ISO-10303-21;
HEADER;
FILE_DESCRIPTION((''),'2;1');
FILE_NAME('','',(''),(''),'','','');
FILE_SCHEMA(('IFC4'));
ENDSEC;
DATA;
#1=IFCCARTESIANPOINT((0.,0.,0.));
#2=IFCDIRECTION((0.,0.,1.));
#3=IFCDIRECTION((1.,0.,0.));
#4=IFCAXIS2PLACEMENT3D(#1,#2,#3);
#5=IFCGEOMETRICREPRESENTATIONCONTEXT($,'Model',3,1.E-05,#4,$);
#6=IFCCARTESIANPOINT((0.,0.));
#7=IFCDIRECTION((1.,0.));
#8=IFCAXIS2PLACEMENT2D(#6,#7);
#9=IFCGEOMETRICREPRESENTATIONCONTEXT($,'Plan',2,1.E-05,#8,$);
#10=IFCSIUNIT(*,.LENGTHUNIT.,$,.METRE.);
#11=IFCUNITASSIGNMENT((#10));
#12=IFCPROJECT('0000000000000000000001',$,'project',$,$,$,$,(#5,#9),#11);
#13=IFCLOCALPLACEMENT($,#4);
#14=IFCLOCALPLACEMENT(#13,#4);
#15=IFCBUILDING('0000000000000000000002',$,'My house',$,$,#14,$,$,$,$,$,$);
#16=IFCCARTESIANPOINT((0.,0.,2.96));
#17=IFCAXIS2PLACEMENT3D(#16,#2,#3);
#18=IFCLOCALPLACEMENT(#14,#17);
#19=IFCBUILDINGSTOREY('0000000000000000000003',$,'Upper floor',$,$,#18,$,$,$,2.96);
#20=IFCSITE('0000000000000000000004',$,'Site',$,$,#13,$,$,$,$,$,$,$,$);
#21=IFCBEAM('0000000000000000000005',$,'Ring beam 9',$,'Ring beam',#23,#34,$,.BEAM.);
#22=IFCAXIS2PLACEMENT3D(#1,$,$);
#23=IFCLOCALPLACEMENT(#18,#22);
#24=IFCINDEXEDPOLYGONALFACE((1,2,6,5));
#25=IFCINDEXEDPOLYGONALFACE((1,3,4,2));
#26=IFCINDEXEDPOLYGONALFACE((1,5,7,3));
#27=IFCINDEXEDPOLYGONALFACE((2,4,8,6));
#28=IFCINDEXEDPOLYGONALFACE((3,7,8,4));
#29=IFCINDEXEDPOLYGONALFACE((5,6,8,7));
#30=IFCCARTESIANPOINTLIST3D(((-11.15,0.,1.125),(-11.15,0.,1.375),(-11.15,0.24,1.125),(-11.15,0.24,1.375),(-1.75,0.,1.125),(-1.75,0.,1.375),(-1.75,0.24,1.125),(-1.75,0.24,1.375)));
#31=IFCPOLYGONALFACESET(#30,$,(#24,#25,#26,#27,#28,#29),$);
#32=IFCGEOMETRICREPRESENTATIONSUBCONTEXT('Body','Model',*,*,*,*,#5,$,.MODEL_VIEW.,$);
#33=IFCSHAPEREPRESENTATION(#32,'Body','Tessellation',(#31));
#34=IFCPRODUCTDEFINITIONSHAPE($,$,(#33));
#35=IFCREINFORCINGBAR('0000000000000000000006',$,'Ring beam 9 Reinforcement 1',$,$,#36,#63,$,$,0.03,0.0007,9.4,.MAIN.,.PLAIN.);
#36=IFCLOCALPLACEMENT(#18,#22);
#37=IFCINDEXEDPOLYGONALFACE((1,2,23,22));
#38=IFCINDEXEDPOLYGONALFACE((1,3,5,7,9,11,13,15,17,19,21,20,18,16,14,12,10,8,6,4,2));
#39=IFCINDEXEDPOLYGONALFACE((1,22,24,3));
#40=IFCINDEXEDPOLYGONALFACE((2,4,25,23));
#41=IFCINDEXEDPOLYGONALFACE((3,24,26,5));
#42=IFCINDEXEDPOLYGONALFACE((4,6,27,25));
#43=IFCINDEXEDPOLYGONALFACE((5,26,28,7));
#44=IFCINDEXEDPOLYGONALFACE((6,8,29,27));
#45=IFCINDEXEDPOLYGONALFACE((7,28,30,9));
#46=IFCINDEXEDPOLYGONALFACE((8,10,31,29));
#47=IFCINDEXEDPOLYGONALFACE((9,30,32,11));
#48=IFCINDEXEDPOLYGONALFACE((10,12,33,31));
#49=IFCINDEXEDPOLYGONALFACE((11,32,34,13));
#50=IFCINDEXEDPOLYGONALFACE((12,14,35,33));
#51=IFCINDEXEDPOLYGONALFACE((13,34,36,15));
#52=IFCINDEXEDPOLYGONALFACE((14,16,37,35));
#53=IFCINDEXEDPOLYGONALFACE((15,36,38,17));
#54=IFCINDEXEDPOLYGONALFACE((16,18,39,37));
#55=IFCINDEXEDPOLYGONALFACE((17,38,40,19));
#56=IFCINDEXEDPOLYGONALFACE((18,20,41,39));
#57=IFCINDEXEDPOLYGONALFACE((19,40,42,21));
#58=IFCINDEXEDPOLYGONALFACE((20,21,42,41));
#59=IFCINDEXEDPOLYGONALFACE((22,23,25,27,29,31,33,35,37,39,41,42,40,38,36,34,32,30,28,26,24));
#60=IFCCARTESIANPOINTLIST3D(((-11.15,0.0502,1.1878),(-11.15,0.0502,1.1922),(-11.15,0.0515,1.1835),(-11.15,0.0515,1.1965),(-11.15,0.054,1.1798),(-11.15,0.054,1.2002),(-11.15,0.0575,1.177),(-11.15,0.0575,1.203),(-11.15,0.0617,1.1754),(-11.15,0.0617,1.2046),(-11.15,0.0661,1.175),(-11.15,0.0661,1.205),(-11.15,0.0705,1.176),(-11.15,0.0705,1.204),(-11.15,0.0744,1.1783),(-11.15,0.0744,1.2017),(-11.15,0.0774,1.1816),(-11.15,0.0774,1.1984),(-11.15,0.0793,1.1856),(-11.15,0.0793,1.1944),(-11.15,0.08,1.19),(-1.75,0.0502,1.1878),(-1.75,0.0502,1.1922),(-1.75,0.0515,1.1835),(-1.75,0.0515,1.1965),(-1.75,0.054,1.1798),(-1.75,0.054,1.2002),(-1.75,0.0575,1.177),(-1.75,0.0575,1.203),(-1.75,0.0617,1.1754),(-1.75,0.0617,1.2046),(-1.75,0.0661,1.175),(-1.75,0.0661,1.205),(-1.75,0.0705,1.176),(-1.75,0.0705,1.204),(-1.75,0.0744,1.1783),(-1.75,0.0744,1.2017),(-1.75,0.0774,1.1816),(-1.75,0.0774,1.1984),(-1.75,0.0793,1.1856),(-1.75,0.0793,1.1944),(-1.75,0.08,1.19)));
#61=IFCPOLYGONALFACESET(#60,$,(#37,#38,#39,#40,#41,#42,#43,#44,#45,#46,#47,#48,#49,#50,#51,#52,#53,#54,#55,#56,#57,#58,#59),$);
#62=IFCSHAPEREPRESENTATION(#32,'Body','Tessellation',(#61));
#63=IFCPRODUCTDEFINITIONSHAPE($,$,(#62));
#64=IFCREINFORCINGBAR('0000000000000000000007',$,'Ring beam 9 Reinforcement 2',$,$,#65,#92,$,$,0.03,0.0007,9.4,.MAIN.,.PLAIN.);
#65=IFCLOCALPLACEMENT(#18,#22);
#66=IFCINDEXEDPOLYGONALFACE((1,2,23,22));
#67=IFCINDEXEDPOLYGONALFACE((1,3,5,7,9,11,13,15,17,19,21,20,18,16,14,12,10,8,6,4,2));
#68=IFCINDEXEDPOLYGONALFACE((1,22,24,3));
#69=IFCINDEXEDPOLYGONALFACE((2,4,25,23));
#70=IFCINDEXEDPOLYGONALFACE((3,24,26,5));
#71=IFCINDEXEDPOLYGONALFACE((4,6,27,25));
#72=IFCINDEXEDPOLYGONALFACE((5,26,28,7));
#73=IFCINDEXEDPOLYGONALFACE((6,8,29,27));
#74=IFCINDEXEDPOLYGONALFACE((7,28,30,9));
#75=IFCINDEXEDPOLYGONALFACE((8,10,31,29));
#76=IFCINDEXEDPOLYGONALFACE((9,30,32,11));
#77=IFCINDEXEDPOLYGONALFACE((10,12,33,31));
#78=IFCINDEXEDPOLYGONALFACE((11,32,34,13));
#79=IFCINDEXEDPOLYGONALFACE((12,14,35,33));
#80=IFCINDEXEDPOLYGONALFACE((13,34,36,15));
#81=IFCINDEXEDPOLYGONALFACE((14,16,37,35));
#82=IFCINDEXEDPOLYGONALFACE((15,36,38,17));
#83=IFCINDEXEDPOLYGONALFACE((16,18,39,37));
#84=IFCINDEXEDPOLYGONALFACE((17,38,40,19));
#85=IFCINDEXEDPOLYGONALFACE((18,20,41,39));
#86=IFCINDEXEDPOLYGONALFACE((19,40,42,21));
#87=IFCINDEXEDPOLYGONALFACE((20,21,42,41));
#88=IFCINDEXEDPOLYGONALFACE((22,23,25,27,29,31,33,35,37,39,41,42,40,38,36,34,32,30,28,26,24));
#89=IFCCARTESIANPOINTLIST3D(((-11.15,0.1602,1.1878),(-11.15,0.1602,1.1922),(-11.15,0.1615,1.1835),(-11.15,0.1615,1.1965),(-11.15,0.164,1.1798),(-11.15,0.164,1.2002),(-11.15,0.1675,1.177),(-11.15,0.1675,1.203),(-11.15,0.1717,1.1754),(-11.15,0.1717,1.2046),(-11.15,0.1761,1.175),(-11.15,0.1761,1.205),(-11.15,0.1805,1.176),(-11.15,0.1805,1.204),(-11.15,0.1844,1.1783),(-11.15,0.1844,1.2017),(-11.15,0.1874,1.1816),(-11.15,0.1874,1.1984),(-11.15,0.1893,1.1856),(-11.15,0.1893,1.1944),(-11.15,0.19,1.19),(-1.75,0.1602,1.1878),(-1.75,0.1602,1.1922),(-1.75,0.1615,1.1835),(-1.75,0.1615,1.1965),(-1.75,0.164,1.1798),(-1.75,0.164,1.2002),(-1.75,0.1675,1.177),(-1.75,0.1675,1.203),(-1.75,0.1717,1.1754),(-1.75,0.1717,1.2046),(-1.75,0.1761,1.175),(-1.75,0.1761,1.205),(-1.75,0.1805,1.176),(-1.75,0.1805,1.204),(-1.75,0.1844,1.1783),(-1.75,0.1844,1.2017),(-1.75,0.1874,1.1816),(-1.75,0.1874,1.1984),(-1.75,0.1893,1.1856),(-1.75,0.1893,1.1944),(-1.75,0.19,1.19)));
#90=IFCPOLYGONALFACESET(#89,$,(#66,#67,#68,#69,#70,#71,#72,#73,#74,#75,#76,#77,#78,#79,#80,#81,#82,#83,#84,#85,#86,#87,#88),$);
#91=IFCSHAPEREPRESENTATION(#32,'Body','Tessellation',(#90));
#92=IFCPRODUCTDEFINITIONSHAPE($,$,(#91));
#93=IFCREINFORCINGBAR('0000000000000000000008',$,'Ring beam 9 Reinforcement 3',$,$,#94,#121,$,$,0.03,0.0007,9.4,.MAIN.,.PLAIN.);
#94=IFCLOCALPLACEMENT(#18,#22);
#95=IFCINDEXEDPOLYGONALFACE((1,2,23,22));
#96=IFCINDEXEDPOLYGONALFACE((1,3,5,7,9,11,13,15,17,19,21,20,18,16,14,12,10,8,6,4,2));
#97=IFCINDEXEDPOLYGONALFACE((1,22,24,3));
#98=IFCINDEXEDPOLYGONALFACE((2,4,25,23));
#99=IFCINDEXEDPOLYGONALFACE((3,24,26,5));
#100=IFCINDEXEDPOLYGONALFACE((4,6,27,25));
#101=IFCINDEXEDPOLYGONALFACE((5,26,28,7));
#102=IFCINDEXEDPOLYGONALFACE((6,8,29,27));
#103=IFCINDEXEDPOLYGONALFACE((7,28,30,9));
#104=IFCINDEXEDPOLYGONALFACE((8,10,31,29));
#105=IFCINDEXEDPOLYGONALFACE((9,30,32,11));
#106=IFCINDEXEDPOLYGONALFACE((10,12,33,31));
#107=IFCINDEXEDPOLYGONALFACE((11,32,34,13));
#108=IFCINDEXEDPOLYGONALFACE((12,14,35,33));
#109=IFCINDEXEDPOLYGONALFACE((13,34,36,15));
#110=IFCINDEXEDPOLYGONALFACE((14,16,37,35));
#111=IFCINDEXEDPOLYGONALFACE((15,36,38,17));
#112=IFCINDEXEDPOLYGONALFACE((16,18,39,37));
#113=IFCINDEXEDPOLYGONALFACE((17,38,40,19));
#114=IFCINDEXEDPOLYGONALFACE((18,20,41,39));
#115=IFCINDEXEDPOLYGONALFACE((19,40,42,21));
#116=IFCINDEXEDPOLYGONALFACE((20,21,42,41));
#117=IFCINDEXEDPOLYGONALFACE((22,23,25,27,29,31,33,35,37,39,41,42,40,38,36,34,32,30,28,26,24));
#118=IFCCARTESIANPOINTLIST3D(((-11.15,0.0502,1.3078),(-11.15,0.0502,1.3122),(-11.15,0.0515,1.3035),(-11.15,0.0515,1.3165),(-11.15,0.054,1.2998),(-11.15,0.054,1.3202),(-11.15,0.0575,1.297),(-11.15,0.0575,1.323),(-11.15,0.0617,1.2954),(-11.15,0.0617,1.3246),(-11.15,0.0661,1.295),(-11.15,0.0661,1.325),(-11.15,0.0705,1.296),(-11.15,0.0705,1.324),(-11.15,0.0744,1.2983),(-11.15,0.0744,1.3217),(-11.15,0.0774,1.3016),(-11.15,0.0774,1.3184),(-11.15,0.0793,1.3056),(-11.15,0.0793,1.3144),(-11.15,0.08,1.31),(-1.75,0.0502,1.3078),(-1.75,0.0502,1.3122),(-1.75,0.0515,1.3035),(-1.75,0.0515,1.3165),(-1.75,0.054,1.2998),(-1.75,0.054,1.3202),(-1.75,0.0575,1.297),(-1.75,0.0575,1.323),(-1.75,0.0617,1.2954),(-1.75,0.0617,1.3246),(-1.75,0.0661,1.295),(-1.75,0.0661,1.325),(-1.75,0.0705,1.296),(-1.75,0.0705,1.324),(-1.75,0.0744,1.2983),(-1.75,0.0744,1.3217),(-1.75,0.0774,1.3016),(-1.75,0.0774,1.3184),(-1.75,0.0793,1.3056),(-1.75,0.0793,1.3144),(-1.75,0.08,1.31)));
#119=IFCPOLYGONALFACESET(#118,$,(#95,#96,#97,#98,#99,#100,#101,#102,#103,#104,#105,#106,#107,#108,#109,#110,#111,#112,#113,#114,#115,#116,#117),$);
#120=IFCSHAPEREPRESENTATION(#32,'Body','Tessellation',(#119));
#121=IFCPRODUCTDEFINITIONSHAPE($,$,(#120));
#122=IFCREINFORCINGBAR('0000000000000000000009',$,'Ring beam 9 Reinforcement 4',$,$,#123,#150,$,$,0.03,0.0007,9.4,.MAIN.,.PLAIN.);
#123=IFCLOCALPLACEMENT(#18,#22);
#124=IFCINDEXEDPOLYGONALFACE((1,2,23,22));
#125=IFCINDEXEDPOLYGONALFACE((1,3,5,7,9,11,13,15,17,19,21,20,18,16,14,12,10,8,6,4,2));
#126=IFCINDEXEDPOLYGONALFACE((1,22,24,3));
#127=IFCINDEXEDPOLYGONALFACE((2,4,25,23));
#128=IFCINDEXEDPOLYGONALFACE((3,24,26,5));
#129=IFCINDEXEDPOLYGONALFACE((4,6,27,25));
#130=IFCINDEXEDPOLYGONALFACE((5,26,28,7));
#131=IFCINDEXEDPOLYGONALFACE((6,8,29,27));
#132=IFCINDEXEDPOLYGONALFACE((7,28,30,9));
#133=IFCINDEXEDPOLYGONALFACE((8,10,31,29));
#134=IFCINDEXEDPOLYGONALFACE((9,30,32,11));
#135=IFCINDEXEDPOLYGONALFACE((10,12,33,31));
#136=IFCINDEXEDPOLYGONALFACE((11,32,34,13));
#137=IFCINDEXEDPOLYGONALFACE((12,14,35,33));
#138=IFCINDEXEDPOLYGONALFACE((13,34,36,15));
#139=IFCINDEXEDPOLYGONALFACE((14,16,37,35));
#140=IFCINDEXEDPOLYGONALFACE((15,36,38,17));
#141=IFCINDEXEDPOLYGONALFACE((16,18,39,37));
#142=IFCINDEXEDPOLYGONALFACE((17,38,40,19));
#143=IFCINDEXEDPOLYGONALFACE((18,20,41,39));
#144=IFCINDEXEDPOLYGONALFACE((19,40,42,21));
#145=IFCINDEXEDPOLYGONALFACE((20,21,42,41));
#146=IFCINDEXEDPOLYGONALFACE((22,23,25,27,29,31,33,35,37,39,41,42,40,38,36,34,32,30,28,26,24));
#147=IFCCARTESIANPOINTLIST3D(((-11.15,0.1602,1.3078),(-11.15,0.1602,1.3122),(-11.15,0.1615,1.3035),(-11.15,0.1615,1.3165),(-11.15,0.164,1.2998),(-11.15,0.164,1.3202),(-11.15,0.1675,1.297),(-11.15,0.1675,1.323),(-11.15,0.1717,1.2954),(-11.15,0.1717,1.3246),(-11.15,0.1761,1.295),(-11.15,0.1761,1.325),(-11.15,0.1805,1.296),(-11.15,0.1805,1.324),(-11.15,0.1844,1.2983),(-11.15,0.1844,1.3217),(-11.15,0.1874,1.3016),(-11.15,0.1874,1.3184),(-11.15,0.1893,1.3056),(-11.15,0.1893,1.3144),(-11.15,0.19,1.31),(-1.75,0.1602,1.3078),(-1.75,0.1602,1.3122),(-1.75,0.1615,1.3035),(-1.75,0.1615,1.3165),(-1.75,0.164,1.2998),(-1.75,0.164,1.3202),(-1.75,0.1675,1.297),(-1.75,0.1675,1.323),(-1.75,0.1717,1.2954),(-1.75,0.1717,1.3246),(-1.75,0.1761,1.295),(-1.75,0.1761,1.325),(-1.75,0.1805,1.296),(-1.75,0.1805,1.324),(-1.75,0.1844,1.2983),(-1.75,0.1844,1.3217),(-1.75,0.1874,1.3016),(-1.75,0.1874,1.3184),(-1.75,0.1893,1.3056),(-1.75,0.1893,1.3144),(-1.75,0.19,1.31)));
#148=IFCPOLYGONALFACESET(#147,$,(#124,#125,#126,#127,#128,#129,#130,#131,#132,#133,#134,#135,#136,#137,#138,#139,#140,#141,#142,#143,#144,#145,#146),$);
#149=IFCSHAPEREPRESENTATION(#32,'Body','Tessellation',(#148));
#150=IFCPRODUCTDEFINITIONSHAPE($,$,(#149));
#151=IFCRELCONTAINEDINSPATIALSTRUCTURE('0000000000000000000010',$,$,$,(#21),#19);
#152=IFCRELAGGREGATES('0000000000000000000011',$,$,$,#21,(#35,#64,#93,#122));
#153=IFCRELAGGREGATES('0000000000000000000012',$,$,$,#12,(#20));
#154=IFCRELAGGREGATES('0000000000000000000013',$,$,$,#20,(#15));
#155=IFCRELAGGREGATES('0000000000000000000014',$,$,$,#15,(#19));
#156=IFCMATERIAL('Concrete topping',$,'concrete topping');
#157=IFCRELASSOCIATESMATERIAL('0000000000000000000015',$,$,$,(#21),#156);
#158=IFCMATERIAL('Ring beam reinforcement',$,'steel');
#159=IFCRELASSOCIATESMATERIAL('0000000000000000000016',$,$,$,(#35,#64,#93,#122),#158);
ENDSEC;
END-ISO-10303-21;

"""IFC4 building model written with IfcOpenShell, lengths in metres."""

from ifc_helpers import new_model, si_unit, frame, origin_with_axes, origin_2d, origin_2d_with_axis, place, context, subcontext, project, spatial, circle_curve, rectangle, outline, extrude, source, transform, mapped, material, element, aggregate, save


model = new_model("IFC4")

# Units and contexts
model_context = context("Model", 3, precision=1e-05, world=origin_with_axes())
plan_context = context("Plan", 2, precision=1e-05, world=origin_2d_with_axis())
body_context = subcontext(model_context, "Body", "Model", "MODEL_VIEW")
ifc_project = project(units=[si_unit("LENGTHUNIT", "METRE")], contexts=[model_context, plan_context])

# Site, building, storey
site_placement = place(None, origin_with_axes())
site = spatial("IfcSite", under=ifc_project, at=site_placement, Name="Site")
building_placement = place(site_placement, origin_with_axes())
building = spatial("IfcBuilding", under=site, at=building_placement, Name="My house")
storey_placement = place(building_placement, frame((0.0, 0.0, 2.96), z_axis=(0.0, 0.0, 1.0), x_axis=(1.0, 0.0, 0.0)))
storey = spatial("IfcBuildingStorey", under=building, at=storey_placement, Name="Upper floor", Elevation=2.96)

# Beam
ifc_material_1 = material(Name="Concrete topping", Category="concrete topping")
shared_shape_1 = source(origin_with_axes(), body_context, "Body", "SweptSolid", [
    extrude(rectangle(XDim=0.24, YDim=0.25), frame((0.0, 0.0, 0.0), z_axis=(1.0, 0.0, 0.0), x_axis=(0.0, 1.0, 0.0)), (0.0, 0.0, 1.0), 9.4),
])
beam_1_placement = place(storey_placement, frame((-1.75, 0.12, 1.25), z_axis=(0.0, 0.0, 1.0), x_axis=(1.0, 0.0, 0.0)))
beam_1 = element("IfcBeam", 1, at=beam_1_placement, inside=storey, material=ifc_material_1, Name="Ring beam 9", ObjectType="Ring beam", PredefinedType="BEAM", context=body_context, shape_type="MappedRepresentation", body=[
    mapped(shared_shape_1, transform((0.0, 0.0, 0.0), x_axis=(-1.0, 0.0, 0.0), y_axis=(0.0, 1.0, 0.0), z_axis=(0.0, 0.0, 1.0), scale=1.0)),
])

# Reinforcing bars
ifc_material_2 = material(Name="Ring beam reinforcement", Category="steel")
shared_shape_2 = source(origin_with_axes(), body_context, "Body", "SweptSolid", [
    extrude(outline(circle_curve(origin_2d(), 0.015)), frame((0.0, 0.0, 0.0), z_axis=(1.0, 0.0, 0.0), x_axis=(0.0, 1.0, 0.0)), (0.0, 0.0, 1.0), 9.4),
])
reinforcing_bar_1_placement = place(beam_1_placement, frame((0.0, -0.055, -0.06), z_axis=(0.0, 0.0, 1.0), x_axis=(1.0, 0.0, 0.0)))
reinforcing_bar_1 = element("IfcReinforcingBar", 2, at=reinforcing_bar_1_placement, material=ifc_material_2, Name="Ring beam 9 Reinforcement 1", BarLength=9.4, BarSurface="PLAIN", CrossSectionArea=0.0007, NominalDiameter=0.03, PredefinedType="MAIN", context=body_context, shape_type="MappedRepresentation", body=[
    mapped(shared_shape_2, transform((0.0, 0.0, 0.0), x_axis=(-1.0, 0.0, 0.0), y_axis=(0.0, 1.0, 0.0), z_axis=(0.0, 0.0, 1.0), scale=1.0)),
])
shared_shape_3 = source(origin_with_axes(), body_context, "Body", "SweptSolid", [
    extrude(outline(circle_curve(origin_2d(), 0.015)), frame((0.0, 0.0, 0.0), z_axis=(1.0, 0.0, 0.0), x_axis=(0.0, 1.0, 0.0)), (0.0, 0.0, 1.0), 9.4),
])
reinforcing_bar_2_placement = place(beam_1_placement, frame((0.0, 0.055, -0.06), z_axis=(0.0, 0.0, 1.0), x_axis=(1.0, 0.0, 0.0)))
reinforcing_bar_2 = element("IfcReinforcingBar", 3, at=reinforcing_bar_2_placement, material=ifc_material_2, Name="Ring beam 9 Reinforcement 2", BarLength=9.4, BarSurface="PLAIN", CrossSectionArea=0.0007, NominalDiameter=0.03, PredefinedType="MAIN", context=body_context, shape_type="MappedRepresentation", body=[
    mapped(shared_shape_3, transform((0.0, 0.0, 0.0), x_axis=(-1.0, 0.0, 0.0), y_axis=(0.0, 1.0, 0.0), z_axis=(0.0, 0.0, 1.0), scale=1.0)),
])
shared_shape_4 = source(origin_with_axes(), body_context, "Body", "SweptSolid", [
    extrude(outline(circle_curve(origin_2d(), 0.015)), frame((0.0, 0.0, 0.0), z_axis=(1.0, 0.0, 0.0), x_axis=(0.0, 1.0, 0.0)), (0.0, 0.0, 1.0), 9.4),
])
reinforcing_bar_3_placement = place(beam_1_placement, frame((0.0, -0.055, 0.06), z_axis=(0.0, 0.0, 1.0), x_axis=(1.0, 0.0, 0.0)))
reinforcing_bar_3 = element("IfcReinforcingBar", 4, at=reinforcing_bar_3_placement, material=ifc_material_2, Name="Ring beam 9 Reinforcement 3", BarLength=9.4, BarSurface="PLAIN", CrossSectionArea=0.0007, NominalDiameter=0.03, PredefinedType="MAIN", context=body_context, shape_type="MappedRepresentation", body=[
    mapped(shared_shape_4, transform((0.0, 0.0, 0.0), x_axis=(-1.0, 0.0, 0.0), y_axis=(0.0, 1.0, 0.0), z_axis=(0.0, 0.0, 1.0), scale=1.0)),
])
shared_shape_5 = source(origin_with_axes(), body_context, "Body", "SweptSolid", [
    extrude(outline(circle_curve(origin_2d(), 0.015)), frame((0.0, 0.0, 0.0), z_axis=(1.0, 0.0, 0.0), x_axis=(0.0, 1.0, 0.0)), (0.0, 0.0, 1.0), 9.4),
])
reinforcing_bar_4_placement = place(beam_1_placement, frame((0.0, 0.055, 0.06), z_axis=(0.0, 0.0, 1.0), x_axis=(1.0, 0.0, 0.0)))
reinforcing_bar_4 = element("IfcReinforcingBar", 5, at=reinforcing_bar_4_placement, material=ifc_material_2, Name="Ring beam 9 Reinforcement 4", BarLength=9.4, BarSurface="PLAIN", CrossSectionArea=0.0007, NominalDiameter=0.03, PredefinedType="MAIN", context=body_context, shape_type="MappedRepresentation", body=[
    mapped(shared_shape_5, transform((0.0, 0.0, 0.0), x_axis=(-1.0, 0.0, 0.0), y_axis=(0.0, 1.0, 0.0), z_axis=(0.0, 0.0, 1.0), scale=1.0)),
])
aggregate(beam_1, [reinforcing_bar_1, reinforcing_bar_2, reinforcing_bar_3, reinforcing_bar_4])

save(model, "model.ifc")
